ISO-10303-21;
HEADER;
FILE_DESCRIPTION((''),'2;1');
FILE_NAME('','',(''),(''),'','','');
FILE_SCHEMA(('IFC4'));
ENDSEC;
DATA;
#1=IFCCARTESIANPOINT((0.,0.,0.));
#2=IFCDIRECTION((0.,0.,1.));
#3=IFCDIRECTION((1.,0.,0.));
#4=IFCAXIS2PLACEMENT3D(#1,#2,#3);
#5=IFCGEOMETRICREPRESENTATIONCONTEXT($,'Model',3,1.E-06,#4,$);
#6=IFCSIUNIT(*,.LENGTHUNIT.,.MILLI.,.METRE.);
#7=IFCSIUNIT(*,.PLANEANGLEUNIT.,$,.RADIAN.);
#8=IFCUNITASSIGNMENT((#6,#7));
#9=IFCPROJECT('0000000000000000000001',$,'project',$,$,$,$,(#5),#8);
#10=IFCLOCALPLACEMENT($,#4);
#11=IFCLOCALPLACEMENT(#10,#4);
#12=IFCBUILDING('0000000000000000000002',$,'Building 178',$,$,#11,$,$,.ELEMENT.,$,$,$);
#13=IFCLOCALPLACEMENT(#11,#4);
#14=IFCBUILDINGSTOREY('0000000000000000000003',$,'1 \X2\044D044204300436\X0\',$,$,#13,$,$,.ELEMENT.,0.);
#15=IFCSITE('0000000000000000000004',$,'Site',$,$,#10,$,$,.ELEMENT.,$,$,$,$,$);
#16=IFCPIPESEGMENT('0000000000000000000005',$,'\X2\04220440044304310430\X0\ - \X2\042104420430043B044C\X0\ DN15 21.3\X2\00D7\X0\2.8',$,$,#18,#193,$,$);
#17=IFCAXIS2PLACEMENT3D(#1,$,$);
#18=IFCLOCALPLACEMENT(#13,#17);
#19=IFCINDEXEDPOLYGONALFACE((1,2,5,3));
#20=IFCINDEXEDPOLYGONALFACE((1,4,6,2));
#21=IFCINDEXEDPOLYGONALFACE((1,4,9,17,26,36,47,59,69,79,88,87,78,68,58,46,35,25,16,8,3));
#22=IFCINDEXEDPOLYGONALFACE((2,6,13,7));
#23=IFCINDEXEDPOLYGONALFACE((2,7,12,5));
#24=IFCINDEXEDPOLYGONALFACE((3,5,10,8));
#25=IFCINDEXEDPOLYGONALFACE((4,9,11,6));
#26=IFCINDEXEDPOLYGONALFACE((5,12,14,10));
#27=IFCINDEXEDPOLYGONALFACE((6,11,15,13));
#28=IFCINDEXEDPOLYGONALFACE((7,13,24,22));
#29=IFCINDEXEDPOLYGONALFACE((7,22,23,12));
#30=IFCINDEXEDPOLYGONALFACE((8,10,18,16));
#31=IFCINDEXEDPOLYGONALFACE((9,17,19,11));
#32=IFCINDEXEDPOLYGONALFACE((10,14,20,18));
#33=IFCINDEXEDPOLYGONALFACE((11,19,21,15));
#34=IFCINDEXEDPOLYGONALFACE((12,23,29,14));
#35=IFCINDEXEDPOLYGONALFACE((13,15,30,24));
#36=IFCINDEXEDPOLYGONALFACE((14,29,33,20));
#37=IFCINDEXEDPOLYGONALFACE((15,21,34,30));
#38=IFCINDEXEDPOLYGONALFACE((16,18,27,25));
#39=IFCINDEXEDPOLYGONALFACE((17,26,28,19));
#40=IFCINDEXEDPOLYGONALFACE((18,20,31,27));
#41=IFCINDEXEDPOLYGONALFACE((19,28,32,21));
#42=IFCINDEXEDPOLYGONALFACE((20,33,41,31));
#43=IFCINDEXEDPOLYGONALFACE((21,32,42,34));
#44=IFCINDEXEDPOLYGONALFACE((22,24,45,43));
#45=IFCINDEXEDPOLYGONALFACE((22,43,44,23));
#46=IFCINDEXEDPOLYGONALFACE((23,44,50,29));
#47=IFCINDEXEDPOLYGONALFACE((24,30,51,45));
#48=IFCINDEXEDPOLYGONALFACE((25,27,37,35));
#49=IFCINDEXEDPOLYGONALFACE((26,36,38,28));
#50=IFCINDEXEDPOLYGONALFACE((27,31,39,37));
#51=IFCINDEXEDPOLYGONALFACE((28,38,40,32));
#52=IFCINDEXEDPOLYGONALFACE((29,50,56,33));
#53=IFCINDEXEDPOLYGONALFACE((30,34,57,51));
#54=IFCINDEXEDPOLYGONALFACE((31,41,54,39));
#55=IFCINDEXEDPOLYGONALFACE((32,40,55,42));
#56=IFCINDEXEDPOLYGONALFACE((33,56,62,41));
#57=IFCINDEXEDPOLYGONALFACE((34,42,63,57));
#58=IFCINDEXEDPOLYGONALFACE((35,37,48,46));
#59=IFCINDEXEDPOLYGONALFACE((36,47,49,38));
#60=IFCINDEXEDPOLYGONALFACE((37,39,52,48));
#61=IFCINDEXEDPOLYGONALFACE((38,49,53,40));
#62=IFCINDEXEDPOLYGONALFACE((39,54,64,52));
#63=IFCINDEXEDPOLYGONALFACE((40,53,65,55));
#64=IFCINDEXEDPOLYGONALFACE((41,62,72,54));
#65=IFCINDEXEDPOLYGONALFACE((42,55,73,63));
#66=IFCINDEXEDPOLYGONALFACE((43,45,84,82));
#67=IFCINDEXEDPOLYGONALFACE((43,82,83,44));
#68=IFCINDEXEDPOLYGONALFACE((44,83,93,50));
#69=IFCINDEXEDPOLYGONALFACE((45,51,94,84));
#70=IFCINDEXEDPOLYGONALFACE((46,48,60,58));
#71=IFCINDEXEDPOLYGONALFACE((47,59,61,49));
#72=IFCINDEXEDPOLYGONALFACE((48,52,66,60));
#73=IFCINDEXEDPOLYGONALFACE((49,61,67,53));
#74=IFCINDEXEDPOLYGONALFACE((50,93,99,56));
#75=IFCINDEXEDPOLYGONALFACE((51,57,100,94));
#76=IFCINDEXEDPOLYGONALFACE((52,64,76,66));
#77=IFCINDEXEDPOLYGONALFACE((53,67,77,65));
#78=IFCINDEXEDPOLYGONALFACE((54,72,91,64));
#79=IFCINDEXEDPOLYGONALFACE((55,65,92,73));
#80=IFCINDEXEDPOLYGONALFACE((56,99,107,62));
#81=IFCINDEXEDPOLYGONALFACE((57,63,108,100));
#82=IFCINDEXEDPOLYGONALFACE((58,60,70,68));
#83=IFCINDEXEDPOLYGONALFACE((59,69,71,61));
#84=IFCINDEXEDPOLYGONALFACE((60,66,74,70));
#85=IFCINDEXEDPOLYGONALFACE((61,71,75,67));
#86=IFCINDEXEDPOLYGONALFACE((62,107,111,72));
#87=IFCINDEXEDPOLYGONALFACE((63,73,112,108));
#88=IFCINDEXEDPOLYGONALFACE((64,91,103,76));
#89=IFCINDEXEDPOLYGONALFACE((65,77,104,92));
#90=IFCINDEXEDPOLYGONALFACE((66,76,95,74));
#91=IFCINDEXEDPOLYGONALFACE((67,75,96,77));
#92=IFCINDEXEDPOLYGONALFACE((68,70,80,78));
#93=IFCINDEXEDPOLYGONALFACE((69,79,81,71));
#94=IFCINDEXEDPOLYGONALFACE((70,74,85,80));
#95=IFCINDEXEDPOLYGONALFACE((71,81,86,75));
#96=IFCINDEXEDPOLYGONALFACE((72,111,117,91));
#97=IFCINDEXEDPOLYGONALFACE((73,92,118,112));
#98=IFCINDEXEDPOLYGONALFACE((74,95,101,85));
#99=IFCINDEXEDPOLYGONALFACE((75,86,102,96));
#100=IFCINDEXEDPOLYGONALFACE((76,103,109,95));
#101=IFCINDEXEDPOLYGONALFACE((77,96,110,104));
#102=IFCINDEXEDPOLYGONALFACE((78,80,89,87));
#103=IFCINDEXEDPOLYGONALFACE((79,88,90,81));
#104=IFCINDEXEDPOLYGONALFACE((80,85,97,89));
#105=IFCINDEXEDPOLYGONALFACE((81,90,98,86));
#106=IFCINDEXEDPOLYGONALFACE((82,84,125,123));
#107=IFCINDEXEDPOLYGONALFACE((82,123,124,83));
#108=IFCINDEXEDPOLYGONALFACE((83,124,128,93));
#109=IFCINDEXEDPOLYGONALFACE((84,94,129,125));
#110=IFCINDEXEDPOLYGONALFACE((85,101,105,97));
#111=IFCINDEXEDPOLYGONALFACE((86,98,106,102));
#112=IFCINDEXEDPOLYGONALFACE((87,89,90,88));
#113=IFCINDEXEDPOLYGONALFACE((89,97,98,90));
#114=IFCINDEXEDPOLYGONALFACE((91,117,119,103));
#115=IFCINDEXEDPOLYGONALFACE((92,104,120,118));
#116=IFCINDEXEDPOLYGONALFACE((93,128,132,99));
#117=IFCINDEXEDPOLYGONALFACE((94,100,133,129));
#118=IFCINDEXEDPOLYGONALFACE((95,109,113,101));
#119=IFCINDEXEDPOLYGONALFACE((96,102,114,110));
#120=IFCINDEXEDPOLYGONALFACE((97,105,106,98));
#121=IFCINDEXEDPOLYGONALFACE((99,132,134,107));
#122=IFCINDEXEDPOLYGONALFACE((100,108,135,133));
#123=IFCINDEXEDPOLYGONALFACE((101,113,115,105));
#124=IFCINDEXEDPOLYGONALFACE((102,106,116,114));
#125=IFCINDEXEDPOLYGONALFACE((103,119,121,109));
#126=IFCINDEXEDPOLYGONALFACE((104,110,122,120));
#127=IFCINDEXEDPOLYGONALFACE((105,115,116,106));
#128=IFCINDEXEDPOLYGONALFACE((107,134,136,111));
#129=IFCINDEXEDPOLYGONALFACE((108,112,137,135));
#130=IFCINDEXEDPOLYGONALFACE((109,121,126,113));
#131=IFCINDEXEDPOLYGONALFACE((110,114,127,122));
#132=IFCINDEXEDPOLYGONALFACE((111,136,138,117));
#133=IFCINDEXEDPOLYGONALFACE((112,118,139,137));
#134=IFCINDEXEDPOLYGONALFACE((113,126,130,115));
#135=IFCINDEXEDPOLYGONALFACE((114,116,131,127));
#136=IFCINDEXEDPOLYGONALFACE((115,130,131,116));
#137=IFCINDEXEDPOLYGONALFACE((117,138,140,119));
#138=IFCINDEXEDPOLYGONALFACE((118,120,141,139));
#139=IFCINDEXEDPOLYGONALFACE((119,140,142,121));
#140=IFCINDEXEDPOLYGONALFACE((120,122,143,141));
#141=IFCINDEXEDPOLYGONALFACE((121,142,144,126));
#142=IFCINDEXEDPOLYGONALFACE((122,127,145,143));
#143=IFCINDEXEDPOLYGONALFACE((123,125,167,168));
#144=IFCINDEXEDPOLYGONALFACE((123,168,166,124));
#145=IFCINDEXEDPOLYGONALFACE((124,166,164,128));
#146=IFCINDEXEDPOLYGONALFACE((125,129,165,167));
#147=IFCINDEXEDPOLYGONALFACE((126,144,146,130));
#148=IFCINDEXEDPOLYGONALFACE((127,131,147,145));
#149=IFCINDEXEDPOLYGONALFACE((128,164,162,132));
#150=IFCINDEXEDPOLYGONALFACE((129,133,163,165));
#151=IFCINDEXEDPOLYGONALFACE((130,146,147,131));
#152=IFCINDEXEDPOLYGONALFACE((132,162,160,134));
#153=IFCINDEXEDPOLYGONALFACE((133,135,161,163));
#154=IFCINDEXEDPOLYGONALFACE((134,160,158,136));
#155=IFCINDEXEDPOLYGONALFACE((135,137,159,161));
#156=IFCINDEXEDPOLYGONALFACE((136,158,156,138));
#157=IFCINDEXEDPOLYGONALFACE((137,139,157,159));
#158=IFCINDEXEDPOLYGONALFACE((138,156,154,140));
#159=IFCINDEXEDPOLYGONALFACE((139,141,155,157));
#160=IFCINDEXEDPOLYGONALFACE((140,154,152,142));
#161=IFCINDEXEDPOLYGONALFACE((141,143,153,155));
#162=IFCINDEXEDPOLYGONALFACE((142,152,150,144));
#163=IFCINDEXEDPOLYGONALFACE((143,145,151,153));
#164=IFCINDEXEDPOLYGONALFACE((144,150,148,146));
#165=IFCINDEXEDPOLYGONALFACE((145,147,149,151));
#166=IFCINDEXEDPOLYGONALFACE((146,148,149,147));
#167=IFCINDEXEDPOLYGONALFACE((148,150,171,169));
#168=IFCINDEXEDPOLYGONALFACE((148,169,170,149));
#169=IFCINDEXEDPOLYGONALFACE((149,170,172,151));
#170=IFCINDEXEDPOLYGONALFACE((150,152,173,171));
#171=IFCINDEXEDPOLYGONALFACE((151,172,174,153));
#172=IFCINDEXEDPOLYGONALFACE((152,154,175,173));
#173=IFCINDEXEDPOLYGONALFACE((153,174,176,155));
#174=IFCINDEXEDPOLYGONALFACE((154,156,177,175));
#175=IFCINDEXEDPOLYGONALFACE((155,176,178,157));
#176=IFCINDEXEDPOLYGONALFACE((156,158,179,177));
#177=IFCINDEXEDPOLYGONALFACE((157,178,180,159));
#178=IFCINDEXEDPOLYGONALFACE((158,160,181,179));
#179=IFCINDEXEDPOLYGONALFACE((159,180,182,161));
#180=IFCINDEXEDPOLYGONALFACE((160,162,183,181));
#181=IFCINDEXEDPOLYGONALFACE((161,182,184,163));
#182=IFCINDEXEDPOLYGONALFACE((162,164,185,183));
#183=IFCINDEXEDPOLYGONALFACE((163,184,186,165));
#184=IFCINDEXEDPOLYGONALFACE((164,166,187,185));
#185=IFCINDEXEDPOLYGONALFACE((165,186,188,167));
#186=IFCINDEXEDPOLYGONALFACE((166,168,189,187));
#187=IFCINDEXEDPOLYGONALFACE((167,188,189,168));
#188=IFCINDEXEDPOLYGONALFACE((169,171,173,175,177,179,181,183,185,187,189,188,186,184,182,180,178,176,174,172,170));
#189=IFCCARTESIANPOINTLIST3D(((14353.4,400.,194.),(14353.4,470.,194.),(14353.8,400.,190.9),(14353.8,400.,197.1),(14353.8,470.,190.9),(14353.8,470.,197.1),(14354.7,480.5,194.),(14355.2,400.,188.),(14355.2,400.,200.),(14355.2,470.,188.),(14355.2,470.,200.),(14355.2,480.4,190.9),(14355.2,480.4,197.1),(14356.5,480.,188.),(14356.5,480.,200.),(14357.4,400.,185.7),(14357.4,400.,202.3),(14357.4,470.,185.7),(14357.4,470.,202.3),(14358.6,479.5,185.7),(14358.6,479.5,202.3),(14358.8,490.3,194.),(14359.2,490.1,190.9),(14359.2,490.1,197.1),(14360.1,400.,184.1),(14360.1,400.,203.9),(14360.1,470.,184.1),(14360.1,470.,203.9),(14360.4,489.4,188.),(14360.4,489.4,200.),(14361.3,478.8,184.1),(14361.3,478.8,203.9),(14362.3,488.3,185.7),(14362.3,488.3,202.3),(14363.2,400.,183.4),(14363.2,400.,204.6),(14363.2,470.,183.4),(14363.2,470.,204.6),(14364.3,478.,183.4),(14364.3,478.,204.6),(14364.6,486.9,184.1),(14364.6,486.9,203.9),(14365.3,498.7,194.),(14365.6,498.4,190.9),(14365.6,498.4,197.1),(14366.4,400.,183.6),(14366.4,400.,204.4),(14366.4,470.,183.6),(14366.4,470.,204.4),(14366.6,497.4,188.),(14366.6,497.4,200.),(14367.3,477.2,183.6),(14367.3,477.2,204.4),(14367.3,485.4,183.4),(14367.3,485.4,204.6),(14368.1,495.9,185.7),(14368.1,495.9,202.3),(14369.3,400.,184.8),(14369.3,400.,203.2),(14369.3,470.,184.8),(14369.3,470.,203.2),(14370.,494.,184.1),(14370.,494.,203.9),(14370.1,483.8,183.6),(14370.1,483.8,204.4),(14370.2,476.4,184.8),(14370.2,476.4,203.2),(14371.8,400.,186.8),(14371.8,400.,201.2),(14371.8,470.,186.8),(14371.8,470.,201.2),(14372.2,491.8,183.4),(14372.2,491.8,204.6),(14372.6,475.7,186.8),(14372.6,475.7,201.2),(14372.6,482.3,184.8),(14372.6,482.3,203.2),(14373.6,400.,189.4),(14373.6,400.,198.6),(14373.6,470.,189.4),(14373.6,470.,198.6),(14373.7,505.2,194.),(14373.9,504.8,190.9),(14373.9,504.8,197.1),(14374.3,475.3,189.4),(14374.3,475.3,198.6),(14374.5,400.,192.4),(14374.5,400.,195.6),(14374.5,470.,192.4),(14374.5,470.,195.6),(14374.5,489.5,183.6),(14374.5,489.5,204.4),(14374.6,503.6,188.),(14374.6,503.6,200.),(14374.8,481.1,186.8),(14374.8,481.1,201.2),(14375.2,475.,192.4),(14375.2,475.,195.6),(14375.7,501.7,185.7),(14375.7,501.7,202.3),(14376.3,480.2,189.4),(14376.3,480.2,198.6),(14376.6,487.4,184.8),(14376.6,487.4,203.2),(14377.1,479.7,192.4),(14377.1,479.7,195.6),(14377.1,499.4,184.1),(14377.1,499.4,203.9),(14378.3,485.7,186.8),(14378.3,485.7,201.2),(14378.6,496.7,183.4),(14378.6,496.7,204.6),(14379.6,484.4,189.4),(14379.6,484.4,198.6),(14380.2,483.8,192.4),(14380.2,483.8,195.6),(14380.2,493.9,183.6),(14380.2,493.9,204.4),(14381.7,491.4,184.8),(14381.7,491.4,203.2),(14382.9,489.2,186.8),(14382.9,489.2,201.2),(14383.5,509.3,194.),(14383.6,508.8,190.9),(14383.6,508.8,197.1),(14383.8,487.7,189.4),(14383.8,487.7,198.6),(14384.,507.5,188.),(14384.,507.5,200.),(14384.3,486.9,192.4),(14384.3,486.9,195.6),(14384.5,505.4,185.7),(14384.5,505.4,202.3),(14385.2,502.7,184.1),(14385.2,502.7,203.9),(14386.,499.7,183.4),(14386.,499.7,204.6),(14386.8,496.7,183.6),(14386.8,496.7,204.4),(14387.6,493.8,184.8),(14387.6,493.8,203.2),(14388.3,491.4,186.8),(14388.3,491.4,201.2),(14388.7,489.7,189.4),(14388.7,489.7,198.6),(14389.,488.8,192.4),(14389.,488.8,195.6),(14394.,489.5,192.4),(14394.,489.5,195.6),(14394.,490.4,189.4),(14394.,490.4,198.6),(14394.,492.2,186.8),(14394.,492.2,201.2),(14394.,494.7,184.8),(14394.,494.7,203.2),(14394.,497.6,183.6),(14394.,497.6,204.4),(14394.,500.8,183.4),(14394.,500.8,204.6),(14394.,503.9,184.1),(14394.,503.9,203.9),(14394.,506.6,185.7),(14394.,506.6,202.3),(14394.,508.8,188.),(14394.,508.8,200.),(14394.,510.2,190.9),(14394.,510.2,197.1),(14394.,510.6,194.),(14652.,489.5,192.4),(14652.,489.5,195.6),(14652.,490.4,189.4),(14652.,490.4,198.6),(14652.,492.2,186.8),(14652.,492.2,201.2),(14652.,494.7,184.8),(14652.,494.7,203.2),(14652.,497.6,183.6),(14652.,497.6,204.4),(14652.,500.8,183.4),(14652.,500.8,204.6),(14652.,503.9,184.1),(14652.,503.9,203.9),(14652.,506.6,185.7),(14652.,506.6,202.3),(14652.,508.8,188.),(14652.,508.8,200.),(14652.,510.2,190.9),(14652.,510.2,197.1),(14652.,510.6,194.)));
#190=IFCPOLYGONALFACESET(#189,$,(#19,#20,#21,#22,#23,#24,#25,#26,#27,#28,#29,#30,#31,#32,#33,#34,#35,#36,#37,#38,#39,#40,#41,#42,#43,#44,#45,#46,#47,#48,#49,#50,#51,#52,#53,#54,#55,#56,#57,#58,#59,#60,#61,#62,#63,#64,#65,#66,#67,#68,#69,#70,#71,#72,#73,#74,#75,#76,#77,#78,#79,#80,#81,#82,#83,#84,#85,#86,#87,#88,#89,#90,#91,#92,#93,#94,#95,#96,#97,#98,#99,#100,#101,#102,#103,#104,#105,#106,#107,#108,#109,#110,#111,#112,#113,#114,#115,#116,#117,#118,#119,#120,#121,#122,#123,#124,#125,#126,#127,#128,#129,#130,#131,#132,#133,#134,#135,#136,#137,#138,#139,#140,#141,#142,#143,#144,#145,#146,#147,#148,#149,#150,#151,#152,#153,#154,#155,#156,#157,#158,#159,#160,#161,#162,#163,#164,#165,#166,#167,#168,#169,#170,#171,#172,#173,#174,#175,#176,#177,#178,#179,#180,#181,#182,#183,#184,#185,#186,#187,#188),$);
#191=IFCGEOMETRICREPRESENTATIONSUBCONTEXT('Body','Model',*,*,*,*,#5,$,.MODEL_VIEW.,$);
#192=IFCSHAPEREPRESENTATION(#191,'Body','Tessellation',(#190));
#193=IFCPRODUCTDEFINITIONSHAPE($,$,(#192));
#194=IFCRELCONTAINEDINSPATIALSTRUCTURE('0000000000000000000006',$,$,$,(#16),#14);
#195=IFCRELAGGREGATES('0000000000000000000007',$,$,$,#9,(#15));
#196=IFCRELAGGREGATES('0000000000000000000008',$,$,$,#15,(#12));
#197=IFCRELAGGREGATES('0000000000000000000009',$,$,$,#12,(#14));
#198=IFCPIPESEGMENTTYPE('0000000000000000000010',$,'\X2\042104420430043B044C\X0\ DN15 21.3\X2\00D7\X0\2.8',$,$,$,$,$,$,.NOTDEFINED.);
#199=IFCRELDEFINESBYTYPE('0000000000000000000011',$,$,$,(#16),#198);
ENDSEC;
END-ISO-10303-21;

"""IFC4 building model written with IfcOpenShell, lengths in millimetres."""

from ifc_helpers import new_model, entity, si_unit, frame, origin_with_axes, place, context, subcontext, project, spatial, source, transform, mapped, type_object, element, save


model = new_model("IFC4")

# Units and contexts
model_context = context("Model", 3, precision=1e-06, world=origin_with_axes())
body_context = subcontext(model_context, "Body", "Model", "MODEL_VIEW")
ifc_project = project(units=[si_unit("LENGTHUNIT", "METRE", prefix="MILLI"), si_unit("PLANEANGLEUNIT", "RADIAN")], contexts=[model_context])

# Site, building, storey
site_placement = place(None, origin_with_axes())
site = spatial("IfcSite", under=ifc_project, at=site_placement, Name="Site", CompositionType="ELEMENT")
building_placement = place(site_placement, origin_with_axes())
building = spatial("IfcBuilding", under=site, at=building_placement, Name="Building 178", CompositionType="ELEMENT")
storey_placement = place(building_placement, origin_with_axes())
storey = spatial("IfcBuildingStorey", under=building, at=storey_placement, Name="1 этаж", CompositionType="ELEMENT", Elevation=0.0)

# Pipe segment
pipe_segment_type = type_object("IfcPipeSegmentType", Name="Сталь DN15 21.3×2.8", PredefinedType="NOTDEFINED")
shared_shape_1 = source(origin_with_axes(), body_context, "Body", "AdvancedSweptSolid", [
    entity("IfcSweptDiskSolid", entity("IfcIndexedPolyCurve", entity("IfcCartesianPointList3D", [[0.0, 0.0, 0.0], [0.0, 0.0, -70.0], [8.8, 0.0, -91.2], [30.0, 0.0, -100.0], [288.0, 0.0, -100.0]]), [entity("IfcLineIndex", [1, 2]), entity("IfcArcIndex", [2, 3, 4]), entity("IfcLineIndex", [4, 5])]), 10.7),
])
for number, where, z_axis, x_axis, name in (
    (1, (14364.0, 400.0, 194.0), (0.0, -1.0, 0.0), (1.0, 0.0, 0.0), "Труба - Сталь DN15 21.3×2.8"),
):
    element("IfcPipeSegment", number, at=place(storey_placement, frame(where, z_axis=z_axis, x_axis=x_axis)), inside=storey, type_object=pipe_segment_type, Name=name, context=body_context, shape_type="MappedRepresentation", body=[
        mapped(shared_shape_1, transform((0.0, 0.0, 0.0), x_axis=(1.0, 0.0, 0.0), y_axis=(0.0, 1.0, 0.0), z_axis=(0.0, 0.0, 1.0), scale=1.0)),
    ])

save(model, "model.ifc")
